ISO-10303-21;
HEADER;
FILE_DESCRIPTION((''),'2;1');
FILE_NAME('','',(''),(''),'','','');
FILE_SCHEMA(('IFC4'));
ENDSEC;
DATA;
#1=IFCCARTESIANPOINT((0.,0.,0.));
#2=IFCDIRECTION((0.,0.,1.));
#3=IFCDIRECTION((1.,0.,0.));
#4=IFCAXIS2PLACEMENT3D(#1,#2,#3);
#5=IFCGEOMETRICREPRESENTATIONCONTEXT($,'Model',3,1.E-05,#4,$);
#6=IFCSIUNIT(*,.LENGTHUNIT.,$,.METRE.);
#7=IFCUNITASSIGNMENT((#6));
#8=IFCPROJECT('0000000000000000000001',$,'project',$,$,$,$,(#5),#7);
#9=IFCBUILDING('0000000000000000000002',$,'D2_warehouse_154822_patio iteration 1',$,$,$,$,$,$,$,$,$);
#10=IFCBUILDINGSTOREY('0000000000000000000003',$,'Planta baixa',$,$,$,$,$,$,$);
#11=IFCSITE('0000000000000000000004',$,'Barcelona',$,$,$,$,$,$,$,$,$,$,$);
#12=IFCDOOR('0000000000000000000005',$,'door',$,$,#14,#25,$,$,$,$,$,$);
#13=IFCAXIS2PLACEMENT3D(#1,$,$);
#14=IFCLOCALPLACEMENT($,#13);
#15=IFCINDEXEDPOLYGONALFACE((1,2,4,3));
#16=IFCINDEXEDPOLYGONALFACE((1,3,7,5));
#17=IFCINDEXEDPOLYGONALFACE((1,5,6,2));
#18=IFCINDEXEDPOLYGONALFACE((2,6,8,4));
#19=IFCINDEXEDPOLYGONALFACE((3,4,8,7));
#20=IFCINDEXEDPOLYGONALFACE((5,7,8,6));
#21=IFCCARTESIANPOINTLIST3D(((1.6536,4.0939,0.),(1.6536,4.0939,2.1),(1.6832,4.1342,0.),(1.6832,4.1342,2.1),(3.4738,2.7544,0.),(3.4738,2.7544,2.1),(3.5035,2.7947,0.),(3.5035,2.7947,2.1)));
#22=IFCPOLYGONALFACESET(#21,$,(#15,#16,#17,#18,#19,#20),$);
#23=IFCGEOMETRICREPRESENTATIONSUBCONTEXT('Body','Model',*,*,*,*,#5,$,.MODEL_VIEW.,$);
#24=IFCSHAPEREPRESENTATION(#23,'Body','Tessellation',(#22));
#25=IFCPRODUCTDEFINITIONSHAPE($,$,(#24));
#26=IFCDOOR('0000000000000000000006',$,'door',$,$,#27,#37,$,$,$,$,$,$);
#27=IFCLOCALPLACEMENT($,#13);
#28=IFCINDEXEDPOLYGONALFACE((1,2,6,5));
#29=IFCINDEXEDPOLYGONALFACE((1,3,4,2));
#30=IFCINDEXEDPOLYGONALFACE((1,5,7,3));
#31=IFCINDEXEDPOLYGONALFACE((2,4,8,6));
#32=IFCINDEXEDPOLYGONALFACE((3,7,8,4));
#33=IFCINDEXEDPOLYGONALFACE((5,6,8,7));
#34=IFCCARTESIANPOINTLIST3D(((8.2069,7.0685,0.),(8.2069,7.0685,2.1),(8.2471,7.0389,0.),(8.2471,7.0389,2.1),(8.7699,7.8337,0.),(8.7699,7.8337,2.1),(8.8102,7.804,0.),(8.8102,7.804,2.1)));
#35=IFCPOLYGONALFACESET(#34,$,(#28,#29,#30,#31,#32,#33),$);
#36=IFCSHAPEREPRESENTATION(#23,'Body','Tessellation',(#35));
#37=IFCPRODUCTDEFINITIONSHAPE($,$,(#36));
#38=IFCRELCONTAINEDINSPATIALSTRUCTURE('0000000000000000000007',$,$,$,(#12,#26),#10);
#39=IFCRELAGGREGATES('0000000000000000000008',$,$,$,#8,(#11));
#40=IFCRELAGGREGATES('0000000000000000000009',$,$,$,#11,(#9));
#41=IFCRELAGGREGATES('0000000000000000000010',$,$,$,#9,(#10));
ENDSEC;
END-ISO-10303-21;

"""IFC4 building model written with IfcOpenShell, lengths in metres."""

from ifc_helpers import new_model, si_unit, origin, origin_with_axes, place, context, subcontext, project, spatial, polyline, outline, extrude, element, save


model = new_model("IFC4")

# Units and contexts
model_context = context("Model", 3, precision=1e-05, world=origin_with_axes())
body_context = subcontext(model_context, "Body", "Model", "MODEL_VIEW")
ifc_project = project(units=[si_unit("LENGTHUNIT", "METRE")], contexts=[model_context])

# Site, building, storey
site = spatial("IfcSite", under=ifc_project, Name="Barcelona")
building = spatial("IfcBuilding", under=site, Name="D2_warehouse_154822_patio iteration 1")
storey = spatial("IfcBuildingStorey", under=building, Name="Planta baixa")

# Doors
door_1_placement = place(None, origin_with_axes())
element("IfcDoor", 1, at=door_1_placement, inside=storey, Name="door", context=body_context, shape_type="SweptSolid", body=[
    extrude(outline(polyline([(3.4738, 2.7544), (1.6536, 4.0939), (1.6832, 4.1342), (3.5035, 2.7947), (3.4738, 2.7544)])), origin(), (0.0, 0.0, 1.0), 2.1),
])
door_2_placement = place(None, origin_with_axes())
element("IfcDoor", 2, at=door_2_placement, inside=storey, Name="door", context=body_context, shape_type="SweptSolid", body=[
    extrude(outline(polyline([(8.2069, 7.0685), (8.7699, 7.8337), (8.8102, 7.804), (8.2471, 7.0389), (8.2069, 7.0685)])), origin(), (0.0, 0.0, 1.0), 2.1),
])

save(model, "model.ifc")
